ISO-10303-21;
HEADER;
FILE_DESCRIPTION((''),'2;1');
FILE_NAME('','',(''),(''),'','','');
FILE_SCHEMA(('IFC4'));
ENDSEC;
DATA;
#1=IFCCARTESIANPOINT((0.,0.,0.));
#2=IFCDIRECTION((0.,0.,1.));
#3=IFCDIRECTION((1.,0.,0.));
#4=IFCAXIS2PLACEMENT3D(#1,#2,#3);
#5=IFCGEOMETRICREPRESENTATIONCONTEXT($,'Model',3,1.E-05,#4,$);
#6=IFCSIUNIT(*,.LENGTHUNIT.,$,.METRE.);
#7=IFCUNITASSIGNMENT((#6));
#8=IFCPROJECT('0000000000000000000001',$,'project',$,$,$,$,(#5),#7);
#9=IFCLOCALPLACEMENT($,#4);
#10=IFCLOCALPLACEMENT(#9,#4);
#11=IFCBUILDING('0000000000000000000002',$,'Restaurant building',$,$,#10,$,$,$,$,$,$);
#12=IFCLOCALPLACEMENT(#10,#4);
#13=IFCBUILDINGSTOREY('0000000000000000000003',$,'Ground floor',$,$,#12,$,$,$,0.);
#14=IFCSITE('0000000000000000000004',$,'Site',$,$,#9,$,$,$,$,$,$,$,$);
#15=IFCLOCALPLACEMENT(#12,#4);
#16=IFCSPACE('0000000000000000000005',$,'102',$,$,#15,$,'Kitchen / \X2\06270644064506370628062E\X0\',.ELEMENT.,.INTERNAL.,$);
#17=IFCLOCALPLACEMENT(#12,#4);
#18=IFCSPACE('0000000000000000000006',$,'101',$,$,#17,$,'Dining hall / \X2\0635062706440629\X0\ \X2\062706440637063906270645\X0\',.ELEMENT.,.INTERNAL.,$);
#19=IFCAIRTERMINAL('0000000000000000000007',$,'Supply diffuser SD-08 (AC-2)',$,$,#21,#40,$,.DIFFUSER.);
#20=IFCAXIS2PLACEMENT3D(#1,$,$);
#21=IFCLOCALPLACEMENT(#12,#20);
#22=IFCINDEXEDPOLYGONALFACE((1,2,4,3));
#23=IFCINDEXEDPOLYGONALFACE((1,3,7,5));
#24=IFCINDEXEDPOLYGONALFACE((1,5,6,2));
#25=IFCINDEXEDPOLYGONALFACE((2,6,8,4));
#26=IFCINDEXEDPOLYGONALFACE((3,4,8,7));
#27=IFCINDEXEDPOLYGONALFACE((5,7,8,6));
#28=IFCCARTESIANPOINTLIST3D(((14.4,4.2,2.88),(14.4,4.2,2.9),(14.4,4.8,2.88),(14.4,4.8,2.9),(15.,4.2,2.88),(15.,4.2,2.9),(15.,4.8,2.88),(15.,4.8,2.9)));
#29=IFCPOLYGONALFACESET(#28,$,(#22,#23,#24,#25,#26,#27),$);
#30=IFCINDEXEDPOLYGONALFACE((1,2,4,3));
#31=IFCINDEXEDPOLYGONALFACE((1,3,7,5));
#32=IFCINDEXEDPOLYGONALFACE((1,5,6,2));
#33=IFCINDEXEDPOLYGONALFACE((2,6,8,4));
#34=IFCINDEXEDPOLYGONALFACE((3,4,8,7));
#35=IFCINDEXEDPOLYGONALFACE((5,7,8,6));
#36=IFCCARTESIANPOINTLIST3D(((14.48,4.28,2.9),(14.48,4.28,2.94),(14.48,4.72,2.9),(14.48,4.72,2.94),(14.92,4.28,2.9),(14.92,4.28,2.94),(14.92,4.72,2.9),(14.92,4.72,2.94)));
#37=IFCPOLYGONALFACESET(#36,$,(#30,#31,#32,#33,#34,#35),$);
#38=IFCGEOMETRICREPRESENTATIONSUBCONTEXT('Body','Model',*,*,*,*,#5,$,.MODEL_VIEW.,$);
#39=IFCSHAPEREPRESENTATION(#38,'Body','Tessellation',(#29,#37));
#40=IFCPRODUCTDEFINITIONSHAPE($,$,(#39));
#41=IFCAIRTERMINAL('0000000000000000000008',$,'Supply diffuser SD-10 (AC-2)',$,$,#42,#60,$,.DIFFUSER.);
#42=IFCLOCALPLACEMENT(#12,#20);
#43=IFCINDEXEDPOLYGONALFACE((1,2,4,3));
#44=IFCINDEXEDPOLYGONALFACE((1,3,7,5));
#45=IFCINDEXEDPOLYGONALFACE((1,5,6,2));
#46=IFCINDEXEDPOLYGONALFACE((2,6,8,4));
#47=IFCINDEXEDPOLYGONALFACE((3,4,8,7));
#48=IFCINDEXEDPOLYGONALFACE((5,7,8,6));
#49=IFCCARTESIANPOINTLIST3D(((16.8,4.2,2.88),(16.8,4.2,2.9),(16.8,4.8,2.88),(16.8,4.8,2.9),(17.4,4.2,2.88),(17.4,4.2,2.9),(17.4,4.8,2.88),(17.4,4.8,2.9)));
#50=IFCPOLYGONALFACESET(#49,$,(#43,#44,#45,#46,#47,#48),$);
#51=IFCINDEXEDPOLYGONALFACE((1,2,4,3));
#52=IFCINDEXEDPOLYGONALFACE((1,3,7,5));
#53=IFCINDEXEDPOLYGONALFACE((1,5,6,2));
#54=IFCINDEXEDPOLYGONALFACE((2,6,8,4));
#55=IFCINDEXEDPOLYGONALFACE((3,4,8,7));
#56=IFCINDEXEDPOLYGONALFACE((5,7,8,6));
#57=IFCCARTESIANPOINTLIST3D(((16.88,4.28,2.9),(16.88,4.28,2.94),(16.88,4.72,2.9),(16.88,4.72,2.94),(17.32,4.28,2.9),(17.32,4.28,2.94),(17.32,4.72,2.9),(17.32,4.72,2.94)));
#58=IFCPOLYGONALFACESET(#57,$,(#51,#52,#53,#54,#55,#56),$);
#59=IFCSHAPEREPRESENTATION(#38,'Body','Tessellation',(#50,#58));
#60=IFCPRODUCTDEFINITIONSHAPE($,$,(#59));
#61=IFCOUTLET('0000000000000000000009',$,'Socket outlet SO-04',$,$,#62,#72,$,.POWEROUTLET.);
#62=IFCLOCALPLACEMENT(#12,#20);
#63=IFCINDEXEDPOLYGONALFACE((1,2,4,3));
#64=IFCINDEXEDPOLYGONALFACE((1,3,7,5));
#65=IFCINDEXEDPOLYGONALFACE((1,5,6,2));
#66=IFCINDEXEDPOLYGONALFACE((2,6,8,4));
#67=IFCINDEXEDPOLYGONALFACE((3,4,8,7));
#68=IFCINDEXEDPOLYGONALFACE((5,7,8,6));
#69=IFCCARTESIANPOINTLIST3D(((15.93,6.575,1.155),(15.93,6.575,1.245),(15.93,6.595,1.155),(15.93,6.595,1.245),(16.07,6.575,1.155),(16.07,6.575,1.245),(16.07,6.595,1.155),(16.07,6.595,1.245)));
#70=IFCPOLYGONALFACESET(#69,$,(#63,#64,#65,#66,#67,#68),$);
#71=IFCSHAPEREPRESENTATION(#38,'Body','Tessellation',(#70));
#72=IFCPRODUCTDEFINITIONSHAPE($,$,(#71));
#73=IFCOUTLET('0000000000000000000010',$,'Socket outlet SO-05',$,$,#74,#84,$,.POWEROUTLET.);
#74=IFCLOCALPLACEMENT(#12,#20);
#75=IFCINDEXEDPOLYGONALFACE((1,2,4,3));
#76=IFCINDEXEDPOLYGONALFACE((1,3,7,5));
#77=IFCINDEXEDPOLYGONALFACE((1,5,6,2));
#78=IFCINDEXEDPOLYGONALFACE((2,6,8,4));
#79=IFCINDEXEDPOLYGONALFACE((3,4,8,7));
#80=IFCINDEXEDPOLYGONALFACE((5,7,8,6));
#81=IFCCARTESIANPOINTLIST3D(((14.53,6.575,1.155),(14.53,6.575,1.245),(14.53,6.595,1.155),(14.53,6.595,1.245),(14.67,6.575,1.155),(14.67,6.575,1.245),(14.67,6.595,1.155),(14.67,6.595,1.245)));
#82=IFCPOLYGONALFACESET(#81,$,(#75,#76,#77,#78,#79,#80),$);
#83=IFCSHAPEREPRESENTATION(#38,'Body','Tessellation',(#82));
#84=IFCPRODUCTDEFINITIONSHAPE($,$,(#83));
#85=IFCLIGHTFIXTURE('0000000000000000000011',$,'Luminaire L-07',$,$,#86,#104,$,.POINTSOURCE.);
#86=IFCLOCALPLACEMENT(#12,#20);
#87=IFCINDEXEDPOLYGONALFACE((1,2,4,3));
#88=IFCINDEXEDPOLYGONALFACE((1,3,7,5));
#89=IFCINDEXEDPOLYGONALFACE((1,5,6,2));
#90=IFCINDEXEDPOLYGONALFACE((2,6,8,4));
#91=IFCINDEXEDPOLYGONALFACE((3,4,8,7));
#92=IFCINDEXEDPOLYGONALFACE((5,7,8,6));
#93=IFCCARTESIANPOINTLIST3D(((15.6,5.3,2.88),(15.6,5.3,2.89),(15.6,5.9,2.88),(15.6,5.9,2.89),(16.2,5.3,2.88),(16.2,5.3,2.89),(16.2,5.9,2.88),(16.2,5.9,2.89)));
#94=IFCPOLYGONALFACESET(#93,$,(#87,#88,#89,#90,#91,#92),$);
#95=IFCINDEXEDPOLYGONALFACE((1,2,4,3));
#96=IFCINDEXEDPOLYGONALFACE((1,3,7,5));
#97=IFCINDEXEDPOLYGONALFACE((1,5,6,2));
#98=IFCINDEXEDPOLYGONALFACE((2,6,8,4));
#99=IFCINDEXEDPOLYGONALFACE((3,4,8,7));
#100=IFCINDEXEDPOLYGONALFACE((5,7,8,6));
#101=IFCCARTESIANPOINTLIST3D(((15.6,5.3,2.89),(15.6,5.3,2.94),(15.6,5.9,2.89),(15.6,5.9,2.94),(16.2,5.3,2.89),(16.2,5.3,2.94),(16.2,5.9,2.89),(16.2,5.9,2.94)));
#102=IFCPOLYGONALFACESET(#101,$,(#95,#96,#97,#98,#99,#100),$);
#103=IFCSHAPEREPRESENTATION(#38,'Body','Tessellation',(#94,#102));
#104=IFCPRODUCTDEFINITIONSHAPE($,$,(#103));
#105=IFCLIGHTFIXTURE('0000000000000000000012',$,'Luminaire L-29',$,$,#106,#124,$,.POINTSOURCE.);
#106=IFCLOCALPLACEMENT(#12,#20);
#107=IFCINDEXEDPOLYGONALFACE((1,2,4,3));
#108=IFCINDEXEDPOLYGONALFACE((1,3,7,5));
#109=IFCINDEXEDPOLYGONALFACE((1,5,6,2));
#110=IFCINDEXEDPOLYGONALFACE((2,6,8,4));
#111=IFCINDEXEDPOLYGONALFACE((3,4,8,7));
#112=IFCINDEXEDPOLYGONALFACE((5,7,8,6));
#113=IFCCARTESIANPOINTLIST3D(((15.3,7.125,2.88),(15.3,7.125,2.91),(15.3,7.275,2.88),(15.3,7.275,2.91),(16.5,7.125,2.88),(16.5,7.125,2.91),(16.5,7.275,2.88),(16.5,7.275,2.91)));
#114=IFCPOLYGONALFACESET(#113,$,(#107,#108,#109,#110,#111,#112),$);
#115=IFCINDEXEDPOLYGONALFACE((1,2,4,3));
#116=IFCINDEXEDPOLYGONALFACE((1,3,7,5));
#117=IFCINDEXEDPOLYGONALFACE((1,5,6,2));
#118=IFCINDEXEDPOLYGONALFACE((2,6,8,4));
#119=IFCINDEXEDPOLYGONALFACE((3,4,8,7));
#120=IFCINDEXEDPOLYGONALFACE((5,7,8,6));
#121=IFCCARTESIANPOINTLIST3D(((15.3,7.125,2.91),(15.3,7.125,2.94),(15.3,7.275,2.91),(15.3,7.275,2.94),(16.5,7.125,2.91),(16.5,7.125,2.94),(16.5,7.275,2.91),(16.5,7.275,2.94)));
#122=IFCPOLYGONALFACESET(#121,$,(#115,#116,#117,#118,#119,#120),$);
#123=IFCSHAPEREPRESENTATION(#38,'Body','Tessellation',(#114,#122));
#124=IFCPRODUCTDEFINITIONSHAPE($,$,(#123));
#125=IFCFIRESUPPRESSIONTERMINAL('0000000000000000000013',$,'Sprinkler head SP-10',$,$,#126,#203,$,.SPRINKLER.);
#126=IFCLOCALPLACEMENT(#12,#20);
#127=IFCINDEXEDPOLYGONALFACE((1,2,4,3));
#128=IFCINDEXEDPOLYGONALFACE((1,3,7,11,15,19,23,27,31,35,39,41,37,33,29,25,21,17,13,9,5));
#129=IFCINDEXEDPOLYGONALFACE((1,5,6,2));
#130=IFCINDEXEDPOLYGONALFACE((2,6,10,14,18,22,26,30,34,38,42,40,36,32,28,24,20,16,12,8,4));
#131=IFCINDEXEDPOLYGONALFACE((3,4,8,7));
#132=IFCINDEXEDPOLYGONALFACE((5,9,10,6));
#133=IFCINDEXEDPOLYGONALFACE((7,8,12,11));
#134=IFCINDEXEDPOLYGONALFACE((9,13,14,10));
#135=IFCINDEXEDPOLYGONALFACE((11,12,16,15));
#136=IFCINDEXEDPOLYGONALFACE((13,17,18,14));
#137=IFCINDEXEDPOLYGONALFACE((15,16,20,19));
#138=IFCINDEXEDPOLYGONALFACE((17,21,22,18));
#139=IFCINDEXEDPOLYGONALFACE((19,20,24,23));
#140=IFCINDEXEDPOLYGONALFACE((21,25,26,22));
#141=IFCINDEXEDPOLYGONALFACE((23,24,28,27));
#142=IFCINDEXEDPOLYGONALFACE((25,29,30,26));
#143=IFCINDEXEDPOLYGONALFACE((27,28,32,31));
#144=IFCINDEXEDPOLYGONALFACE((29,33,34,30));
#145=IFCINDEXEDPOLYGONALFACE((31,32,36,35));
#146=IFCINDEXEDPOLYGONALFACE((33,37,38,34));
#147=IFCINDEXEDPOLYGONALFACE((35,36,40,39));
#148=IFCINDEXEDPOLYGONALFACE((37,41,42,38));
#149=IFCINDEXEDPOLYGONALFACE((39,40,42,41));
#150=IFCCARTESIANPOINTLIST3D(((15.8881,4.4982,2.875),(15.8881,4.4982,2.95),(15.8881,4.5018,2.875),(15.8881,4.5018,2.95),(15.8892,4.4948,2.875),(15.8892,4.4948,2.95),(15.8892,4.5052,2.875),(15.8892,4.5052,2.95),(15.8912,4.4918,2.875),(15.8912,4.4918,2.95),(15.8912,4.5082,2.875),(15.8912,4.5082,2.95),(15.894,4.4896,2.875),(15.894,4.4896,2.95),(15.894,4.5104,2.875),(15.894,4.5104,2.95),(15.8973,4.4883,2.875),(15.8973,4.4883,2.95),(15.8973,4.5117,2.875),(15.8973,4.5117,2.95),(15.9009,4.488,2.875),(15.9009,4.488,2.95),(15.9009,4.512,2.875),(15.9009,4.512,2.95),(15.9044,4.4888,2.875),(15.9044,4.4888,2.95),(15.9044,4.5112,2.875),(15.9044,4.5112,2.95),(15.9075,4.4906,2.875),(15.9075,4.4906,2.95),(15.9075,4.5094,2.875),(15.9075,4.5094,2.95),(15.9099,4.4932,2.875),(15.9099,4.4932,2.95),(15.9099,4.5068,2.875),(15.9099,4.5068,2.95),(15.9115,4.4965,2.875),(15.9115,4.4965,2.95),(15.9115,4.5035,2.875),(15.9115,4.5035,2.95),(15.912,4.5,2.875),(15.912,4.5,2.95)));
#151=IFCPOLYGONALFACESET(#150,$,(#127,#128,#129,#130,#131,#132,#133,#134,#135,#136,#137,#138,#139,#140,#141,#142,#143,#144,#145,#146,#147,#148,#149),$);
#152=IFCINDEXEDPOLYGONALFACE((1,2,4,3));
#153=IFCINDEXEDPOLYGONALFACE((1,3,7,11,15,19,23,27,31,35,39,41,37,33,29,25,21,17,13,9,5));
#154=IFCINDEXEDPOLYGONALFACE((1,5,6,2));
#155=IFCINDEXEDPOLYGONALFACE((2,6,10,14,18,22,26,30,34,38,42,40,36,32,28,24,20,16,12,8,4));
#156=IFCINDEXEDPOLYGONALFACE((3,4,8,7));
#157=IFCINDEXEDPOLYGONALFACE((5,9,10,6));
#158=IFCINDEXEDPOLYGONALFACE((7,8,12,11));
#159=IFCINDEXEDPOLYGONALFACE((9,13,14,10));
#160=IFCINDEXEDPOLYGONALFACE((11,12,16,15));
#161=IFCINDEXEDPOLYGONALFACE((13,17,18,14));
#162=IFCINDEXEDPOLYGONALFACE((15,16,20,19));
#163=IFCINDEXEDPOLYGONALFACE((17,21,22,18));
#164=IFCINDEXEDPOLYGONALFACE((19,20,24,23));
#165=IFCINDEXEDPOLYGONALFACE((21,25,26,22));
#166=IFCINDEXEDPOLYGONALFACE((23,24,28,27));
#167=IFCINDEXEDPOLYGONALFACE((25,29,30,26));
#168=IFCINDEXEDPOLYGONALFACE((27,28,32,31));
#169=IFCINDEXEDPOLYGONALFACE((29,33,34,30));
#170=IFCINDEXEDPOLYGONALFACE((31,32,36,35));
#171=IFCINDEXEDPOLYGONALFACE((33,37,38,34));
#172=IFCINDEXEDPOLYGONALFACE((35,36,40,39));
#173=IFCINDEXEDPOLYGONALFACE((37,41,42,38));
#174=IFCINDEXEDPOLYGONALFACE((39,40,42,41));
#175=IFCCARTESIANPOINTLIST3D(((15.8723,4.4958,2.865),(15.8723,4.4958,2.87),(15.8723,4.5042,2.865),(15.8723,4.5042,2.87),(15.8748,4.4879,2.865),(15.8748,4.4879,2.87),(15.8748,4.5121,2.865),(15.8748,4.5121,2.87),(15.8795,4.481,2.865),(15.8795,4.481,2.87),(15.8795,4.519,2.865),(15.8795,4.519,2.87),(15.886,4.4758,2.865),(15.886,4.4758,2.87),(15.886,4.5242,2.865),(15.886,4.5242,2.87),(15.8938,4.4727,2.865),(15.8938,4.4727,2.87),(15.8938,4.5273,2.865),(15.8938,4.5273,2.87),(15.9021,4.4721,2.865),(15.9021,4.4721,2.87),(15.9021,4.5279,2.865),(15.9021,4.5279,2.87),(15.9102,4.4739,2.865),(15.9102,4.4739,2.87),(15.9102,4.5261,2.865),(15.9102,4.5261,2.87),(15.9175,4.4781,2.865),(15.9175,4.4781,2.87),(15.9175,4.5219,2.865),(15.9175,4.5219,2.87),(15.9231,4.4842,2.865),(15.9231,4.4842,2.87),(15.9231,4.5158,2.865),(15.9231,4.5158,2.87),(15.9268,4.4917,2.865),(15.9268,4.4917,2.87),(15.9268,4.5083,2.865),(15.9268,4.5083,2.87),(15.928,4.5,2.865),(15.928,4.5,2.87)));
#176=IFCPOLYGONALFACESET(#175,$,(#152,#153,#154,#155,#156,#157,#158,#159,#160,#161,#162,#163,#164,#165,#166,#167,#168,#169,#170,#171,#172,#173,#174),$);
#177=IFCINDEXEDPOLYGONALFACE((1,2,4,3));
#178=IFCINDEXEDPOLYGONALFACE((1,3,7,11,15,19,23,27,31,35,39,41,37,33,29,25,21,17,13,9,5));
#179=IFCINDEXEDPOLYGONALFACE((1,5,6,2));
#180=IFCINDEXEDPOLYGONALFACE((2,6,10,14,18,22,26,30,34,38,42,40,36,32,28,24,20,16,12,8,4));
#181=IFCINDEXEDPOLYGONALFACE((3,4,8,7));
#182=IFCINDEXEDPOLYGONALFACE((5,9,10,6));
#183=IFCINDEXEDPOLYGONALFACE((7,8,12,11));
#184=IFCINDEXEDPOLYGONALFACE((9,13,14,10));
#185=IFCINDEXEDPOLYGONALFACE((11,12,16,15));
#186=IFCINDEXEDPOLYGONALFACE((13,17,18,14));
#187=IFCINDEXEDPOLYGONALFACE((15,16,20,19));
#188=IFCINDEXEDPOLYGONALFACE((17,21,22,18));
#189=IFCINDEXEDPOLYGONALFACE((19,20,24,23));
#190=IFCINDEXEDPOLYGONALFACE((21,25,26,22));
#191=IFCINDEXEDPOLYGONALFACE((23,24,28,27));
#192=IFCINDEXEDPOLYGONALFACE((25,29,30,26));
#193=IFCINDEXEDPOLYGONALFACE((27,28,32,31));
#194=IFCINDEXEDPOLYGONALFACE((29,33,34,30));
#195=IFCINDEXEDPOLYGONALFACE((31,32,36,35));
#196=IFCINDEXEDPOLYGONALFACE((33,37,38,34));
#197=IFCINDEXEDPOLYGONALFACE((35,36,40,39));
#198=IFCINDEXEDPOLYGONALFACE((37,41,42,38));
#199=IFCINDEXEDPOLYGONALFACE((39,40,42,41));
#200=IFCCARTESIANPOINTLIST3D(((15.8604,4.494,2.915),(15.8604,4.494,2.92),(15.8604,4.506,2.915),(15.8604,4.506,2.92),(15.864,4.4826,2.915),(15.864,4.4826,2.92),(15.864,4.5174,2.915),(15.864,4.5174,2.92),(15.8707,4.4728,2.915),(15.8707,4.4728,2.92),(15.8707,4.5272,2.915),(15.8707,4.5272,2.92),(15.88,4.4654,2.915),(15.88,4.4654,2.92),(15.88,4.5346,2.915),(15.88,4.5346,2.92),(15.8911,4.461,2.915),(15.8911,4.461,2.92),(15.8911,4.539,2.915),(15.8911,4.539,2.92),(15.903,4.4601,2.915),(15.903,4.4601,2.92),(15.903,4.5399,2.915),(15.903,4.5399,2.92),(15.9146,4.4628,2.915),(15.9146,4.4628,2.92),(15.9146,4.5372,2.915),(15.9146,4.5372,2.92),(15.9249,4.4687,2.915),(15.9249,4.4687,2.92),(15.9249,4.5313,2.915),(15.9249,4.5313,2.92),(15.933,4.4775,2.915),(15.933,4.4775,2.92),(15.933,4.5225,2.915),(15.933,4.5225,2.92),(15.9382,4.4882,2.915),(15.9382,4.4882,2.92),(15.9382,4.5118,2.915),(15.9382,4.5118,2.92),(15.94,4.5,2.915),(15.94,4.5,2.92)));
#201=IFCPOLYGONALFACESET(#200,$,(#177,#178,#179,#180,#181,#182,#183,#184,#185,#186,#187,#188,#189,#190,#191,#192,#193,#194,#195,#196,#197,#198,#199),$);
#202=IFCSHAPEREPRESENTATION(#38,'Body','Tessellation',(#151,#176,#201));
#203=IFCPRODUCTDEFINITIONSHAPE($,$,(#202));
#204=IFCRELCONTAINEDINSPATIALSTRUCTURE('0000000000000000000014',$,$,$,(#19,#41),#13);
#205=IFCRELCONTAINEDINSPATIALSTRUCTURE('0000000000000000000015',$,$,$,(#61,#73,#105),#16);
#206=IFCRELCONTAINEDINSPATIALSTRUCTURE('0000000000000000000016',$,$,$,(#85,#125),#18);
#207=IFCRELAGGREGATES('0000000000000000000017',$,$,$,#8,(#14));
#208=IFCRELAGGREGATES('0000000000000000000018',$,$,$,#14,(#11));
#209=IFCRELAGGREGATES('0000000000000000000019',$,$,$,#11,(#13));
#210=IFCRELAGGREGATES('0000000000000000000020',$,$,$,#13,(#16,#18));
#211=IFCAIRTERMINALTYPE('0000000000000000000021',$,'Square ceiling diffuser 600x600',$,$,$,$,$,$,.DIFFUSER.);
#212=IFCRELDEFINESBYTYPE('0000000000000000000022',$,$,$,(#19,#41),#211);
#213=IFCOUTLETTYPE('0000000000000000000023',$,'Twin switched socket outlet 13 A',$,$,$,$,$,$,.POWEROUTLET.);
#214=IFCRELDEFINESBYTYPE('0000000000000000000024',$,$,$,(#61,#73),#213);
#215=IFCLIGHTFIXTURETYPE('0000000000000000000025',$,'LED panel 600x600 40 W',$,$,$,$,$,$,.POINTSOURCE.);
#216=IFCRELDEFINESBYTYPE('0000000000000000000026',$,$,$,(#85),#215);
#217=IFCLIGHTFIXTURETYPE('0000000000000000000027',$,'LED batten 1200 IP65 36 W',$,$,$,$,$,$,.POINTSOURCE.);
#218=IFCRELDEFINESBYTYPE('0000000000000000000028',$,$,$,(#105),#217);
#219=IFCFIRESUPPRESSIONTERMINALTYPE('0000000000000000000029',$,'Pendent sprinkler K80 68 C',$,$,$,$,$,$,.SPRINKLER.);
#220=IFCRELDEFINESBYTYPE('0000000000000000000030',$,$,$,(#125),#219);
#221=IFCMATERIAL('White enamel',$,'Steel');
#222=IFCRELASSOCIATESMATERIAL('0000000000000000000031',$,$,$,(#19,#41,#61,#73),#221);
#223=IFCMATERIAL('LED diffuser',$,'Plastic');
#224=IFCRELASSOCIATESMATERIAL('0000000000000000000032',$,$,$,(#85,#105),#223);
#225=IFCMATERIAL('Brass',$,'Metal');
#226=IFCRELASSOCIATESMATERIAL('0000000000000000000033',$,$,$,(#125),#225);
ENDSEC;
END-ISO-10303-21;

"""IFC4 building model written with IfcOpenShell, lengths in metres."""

from ifc_helpers import new_model, si_unit, frame, origin, origin_with_axes, origin_2d, place, context, subcontext, project, spatial, rectangle, circle, extrude, source, transform, mapped, material, type_object, type_shapes, element, save


model = new_model("IFC4")

# Units and contexts
model_context = context("Model", 3, precision=1e-05, world=origin_with_axes())
body_context = subcontext(model_context, "Body", "Model", "MODEL_VIEW")
ifc_project = project(units=[si_unit("LENGTHUNIT", "METRE")], contexts=[model_context])

# Site, building, storey
site_placement = place(None, origin_with_axes())
site = spatial("IfcSite", under=ifc_project, at=site_placement, Name="Site")
building_placement = place(site_placement, origin_with_axes())
building = spatial("IfcBuilding", under=site, at=building_placement, Name="Restaurant building")
storey_placement = place(building_placement, origin_with_axes())
storey = spatial("IfcBuildingStorey", under=building, at=storey_placement, Name="Ground floor", Elevation=0.0)

# Air terminals
ifc_material_1 = material(Name="White enamel", Category="Steel")
air_terminal_type = type_object("IfcAirTerminalType", Name="Square ceiling diffuser 600x600", PredefinedType="DIFFUSER")
shared_shape_1 = source(origin(), body_context, "Body", "SweptSolid", [
    extrude(rectangle(XDim=0.6, YDim=0.6, at=origin_2d()), frame((0.0, 0.0, -0.06)), (0.0, 0.0, 1.0), 0.02),
    extrude(rectangle(XDim=0.44, YDim=0.44, at=origin_2d()), frame((0.0, 0.0, -0.04)), (0.0, 0.0, 1.0), 0.04),
])
type_shapes(air_terminal_type, [shared_shape_1])
for number, where, name in (
    (1, (14.7, 4.5, 2.94), "Supply diffuser SD-08 (AC-2)"),
    (2, (17.1, 4.5, 2.94), "Supply diffuser SD-10 (AC-2)"),
):
    element("IfcAirTerminal", number, at=place(storey_placement, frame(where)), inside=storey, type_object=air_terminal_type, material=ifc_material_1, Name=name, PredefinedType="DIFFUSER", context=body_context, shape_type="MappedRepresentation", body=[
        mapped(shared_shape_1, transform((0.0, 0.0, 0.0))),
    ])

# Shared definitions
space_1_placement = place(storey_placement, origin_with_axes())
space_1 = spatial("IfcSpace", under=storey, at=space_1_placement, Name="102", LongName="Kitchen / المطبخ", CompositionType="ELEMENT", PredefinedType="INTERNAL")

# Outlets
outlet_type = type_object("IfcOutletType", Name="Twin switched socket outlet 13 A", PredefinedType="POWEROUTLET")
shared_shape_2 = source(origin(), body_context, "Body", "SweptSolid", [
    extrude(rectangle(XDim=0.14, YDim=0.02, at=origin_2d()), frame((0.0, 0.01, -0.045)), (0.0, 0.0, 1.0), 0.09),
])
type_shapes(outlet_type, [shared_shape_2])
for number, where, name in (
    (3, (16.0, 6.575, 1.2), "Socket outlet SO-04"),
    (4, (14.6, 6.575, 1.2), "Socket outlet SO-05"),
):
    element("IfcOutlet", number, at=place(storey_placement, frame(where)), inside=space_1, type_object=outlet_type, material=ifc_material_1, Name=name, PredefinedType="POWEROUTLET", context=body_context, shape_type="MappedRepresentation", body=[
        mapped(shared_shape_2, transform((0.0, 0.0, 0.0))),
    ])

# Shared definitions
space_2_placement = place(storey_placement, origin_with_axes())
space_2 = spatial("IfcSpace", under=storey, at=space_2_placement, Name="101", LongName="Dining hall / صالة الطعام", CompositionType="ELEMENT", PredefinedType="INTERNAL")

# Light fixtures
ifc_material_2 = material(Name="LED diffuser", Category="Plastic")
light_fixture_type_1 = type_object("IfcLightFixtureType", Name="LED panel 600x600 40 W", PredefinedType="POINTSOURCE")
shared_shape_3 = source(origin(), body_context, "Body", "SweptSolid", [
    extrude(rectangle(XDim=0.6, YDim=0.6, at=origin_2d()), frame((0.0, 0.0, -0.06)), (0.0, 0.0, 1.0), 0.01),
    extrude(rectangle(XDim=0.6, YDim=0.6, at=origin_2d()), frame((0.0, 0.0, -0.05)), (0.0, 0.0, 1.0), 0.05),
])
type_shapes(light_fixture_type_1, [shared_shape_3])
light_fixture_1_placement = place(storey_placement, frame((15.9, 5.6, 2.94)))
element("IfcLightFixture", 5, at=light_fixture_1_placement, inside=space_2, type_object=light_fixture_type_1, material=ifc_material_2, Name="Luminaire L-07", PredefinedType="POINTSOURCE", context=body_context, shape_type="MappedRepresentation", body=[
    mapped(shared_shape_3, transform((0.0, 0.0, 0.0))),
])
light_fixture_type_2 = type_object("IfcLightFixtureType", Name="LED batten 1200 IP65 36 W", PredefinedType="POINTSOURCE")
shared_shape_4 = source(origin(), body_context, "Body", "SweptSolid", [
    extrude(rectangle(XDim=1.2, YDim=0.15, at=origin_2d()), frame((0.0, 0.0, -0.06)), (0.0, 0.0, 1.0), 0.03),
    extrude(rectangle(XDim=1.2, YDim=0.15, at=origin_2d()), frame((0.0, 0.0, -0.03)), (0.0, 0.0, 1.0), 0.03),
])
type_shapes(light_fixture_type_2, [shared_shape_4])
light_fixture_2_placement = place(storey_placement, frame((15.9, 7.2, 2.94)))
element("IfcLightFixture", 6, at=light_fixture_2_placement, inside=space_1, type_object=light_fixture_type_2, material=ifc_material_2, Name="Luminaire L-29", PredefinedType="POINTSOURCE", context=body_context, shape_type="MappedRepresentation", body=[
    mapped(shared_shape_4, transform((0.0, 0.0, 0.0))),
])

# Fire suppression terminal
ifc_material_3 = material(Name="Brass", Category="Metal")
fire_suppression_terminal_type = type_object("IfcFireSuppressionTerminalType", Name="Pendent sprinkler K80 68 C", PredefinedType="SPRINKLER")
shared_shape_5 = source(origin(), body_context, "Body", "SweptSolid", [
    extrude(circle(Radius=0.012, at=origin_2d()), frame((0.0, 0.0, -0.075)), (0.0, 0.0, 1.0), 0.075),
    extrude(circle(Radius=0.028, at=origin_2d()), frame((0.0, 0.0, -0.085)), (0.0, 0.0, 1.0), 0.005),
    extrude(circle(Radius=0.04, at=origin_2d()), frame((0.0, 0.0, -0.035)), (0.0, 0.0, 1.0), 0.005),
])
type_shapes(fire_suppression_terminal_type, [shared_shape_5])
fire_suppression_terminal_placement = place(storey_placement, frame((15.9, 4.5, 2.95)))
element("IfcFireSuppressionTerminal", 7, at=fire_suppression_terminal_placement, inside=space_2, type_object=fire_suppression_terminal_type, material=ifc_material_3, Name="Sprinkler head SP-10", PredefinedType="SPRINKLER", context=body_context, shape_type="MappedRepresentation", body=[
    mapped(shared_shape_5, transform((0.0, 0.0, 0.0))),
])

save(model, "model.ifc")
